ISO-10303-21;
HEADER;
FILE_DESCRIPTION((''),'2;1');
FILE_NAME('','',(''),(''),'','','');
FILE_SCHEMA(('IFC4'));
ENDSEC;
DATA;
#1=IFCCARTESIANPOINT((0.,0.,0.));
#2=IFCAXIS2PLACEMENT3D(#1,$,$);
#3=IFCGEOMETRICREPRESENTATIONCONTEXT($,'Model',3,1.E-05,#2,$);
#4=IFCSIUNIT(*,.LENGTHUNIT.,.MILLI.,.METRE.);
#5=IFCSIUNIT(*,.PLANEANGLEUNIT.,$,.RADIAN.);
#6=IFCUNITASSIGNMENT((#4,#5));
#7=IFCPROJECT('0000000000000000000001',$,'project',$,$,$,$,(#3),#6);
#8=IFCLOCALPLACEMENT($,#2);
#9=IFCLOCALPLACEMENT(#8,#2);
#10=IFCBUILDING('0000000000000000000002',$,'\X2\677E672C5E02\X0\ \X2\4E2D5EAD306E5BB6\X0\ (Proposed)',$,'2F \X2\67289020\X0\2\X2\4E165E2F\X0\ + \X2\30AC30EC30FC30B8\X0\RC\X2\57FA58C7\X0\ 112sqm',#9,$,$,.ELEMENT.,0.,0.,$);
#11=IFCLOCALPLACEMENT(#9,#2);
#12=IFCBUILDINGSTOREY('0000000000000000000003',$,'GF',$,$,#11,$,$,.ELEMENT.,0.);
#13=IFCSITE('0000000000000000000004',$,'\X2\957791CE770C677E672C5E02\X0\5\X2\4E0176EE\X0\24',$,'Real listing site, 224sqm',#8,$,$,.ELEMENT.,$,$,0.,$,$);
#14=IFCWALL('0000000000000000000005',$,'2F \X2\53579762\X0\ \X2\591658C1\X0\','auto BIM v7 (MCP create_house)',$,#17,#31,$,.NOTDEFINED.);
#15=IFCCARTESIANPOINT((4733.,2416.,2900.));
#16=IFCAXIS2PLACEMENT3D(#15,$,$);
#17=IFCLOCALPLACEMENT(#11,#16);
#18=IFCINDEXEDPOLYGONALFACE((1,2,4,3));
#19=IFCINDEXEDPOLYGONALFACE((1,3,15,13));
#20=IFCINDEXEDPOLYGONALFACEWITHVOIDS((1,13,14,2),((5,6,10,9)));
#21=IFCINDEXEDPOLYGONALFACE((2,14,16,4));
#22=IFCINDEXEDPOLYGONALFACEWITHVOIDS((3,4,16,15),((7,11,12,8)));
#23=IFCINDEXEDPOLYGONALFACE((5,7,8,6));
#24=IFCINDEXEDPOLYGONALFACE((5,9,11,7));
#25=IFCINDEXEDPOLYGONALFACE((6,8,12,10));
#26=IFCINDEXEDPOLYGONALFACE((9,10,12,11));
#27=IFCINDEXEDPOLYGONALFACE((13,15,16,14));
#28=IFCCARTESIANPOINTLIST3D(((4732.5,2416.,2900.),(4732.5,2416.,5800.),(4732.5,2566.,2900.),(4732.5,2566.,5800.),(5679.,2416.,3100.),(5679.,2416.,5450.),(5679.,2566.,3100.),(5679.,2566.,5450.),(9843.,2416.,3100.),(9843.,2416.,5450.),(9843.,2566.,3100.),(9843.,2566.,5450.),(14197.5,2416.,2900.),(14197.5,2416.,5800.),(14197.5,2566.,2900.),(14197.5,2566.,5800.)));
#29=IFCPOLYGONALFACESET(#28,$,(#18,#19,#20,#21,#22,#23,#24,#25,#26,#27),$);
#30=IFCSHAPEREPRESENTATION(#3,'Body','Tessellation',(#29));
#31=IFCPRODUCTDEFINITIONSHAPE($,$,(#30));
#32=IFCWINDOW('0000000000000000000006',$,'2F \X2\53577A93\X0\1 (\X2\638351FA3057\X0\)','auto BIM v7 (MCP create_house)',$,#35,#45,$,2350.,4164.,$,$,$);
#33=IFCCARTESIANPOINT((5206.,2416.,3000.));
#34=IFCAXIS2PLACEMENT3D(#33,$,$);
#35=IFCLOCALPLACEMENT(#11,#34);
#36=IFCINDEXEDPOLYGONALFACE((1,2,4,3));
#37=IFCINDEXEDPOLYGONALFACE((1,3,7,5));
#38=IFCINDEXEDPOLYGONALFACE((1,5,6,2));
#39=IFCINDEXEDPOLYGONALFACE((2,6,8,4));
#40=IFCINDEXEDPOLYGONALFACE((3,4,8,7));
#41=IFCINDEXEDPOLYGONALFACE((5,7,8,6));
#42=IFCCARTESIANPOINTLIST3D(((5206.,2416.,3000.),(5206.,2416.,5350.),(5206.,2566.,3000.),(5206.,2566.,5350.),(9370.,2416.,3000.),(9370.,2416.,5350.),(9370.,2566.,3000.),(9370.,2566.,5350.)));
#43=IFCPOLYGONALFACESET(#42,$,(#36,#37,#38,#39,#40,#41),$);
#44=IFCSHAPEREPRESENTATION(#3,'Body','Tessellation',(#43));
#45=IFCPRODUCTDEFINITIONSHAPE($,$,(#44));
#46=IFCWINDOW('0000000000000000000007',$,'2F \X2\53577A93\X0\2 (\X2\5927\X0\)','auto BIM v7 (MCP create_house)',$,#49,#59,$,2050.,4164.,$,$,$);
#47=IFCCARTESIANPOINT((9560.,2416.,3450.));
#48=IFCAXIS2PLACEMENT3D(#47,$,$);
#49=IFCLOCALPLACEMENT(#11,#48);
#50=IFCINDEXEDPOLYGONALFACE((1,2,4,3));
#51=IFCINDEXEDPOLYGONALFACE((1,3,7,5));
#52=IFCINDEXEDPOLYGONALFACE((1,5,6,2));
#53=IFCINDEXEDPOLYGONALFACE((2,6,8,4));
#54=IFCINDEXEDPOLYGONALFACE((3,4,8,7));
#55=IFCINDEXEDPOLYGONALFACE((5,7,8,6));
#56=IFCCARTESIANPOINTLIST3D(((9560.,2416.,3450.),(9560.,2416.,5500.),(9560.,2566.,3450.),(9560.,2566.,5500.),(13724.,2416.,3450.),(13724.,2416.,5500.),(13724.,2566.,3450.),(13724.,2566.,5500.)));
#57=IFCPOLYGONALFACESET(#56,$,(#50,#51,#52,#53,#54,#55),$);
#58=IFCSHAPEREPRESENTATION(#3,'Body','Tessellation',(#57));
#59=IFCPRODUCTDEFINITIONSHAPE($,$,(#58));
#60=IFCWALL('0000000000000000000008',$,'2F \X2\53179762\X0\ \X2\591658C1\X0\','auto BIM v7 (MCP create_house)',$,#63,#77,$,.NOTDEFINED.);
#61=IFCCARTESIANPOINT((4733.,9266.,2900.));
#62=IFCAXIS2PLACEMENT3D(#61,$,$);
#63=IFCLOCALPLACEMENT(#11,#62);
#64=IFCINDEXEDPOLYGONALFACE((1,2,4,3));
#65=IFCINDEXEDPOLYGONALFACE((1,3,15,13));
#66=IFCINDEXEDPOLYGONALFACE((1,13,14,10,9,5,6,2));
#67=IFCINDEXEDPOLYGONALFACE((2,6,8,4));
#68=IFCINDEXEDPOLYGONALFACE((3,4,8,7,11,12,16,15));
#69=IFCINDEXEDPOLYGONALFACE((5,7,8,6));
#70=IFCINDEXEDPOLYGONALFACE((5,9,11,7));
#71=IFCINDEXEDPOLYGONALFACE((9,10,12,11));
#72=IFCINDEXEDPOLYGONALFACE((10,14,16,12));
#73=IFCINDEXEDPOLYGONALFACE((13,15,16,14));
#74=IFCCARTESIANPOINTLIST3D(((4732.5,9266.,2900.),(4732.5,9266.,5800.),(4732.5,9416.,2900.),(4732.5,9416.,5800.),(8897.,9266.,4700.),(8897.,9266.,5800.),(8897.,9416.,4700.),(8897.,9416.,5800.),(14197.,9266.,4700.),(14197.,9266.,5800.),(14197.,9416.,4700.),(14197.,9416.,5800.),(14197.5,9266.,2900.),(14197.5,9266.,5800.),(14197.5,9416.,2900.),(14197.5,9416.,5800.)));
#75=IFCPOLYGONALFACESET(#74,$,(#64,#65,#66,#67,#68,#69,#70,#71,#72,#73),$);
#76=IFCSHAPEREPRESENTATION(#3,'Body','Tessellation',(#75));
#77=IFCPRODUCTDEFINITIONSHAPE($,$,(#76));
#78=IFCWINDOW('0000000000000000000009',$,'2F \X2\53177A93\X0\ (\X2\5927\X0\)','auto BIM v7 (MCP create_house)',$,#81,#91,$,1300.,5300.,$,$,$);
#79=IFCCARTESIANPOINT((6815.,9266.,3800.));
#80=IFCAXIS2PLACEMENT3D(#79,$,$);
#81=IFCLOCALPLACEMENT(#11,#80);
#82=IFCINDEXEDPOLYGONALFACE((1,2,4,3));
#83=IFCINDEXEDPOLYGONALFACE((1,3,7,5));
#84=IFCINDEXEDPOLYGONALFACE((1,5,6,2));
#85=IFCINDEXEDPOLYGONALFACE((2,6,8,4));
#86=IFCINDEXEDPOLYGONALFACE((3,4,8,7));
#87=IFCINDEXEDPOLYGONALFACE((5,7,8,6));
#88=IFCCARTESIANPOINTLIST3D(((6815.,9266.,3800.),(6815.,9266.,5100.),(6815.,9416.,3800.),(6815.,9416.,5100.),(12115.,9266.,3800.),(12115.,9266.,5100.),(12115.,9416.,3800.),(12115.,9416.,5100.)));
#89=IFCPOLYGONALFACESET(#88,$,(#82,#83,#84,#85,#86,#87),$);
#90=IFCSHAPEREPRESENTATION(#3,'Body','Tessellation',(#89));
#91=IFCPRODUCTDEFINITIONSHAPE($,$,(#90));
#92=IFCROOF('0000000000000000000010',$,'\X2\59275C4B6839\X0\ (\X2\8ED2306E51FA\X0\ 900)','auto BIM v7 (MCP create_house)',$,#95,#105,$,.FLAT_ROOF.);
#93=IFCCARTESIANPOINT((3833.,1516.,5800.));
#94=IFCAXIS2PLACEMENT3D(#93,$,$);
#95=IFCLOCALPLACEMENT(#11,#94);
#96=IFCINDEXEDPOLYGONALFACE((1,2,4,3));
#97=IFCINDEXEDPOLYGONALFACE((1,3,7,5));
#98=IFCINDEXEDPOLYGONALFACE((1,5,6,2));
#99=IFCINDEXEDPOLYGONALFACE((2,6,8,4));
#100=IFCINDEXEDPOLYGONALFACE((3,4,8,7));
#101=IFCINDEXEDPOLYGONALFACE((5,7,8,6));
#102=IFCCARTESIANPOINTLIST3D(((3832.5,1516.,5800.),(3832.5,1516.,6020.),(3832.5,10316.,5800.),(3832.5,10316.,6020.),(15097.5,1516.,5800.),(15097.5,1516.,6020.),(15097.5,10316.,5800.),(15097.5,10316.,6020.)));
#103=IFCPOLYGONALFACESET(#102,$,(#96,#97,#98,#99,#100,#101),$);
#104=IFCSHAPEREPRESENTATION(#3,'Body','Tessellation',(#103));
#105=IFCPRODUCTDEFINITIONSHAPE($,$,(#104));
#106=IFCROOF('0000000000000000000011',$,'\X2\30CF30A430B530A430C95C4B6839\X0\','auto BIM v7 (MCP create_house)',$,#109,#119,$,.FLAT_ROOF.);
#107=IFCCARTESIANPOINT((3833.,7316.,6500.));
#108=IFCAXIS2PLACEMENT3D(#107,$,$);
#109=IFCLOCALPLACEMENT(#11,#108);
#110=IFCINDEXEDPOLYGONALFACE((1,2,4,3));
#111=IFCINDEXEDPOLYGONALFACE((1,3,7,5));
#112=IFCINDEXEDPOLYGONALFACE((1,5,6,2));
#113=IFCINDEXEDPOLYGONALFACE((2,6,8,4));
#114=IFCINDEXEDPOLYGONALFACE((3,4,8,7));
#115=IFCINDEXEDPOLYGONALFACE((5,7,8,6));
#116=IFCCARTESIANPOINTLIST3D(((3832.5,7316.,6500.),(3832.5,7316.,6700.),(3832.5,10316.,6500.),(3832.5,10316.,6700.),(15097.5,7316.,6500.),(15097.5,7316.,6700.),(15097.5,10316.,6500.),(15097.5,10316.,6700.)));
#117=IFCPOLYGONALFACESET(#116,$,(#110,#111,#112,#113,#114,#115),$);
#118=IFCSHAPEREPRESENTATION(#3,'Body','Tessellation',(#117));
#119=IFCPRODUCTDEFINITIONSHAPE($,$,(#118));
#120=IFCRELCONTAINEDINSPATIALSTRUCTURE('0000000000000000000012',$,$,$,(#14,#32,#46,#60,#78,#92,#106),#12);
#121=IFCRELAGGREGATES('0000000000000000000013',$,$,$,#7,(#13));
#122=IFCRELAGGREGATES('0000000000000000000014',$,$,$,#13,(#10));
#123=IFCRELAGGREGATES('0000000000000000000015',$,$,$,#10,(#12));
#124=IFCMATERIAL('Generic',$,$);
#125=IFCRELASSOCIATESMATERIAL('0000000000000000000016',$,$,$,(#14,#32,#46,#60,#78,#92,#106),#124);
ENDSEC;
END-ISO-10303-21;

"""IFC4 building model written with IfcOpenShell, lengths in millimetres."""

from ifc_helpers import new_model, si_unit, frame, frame_2d, origin, place, context, project, spatial, rectangle, extrude, material, element, fill, save


model = new_model("IFC4")

# Units and contexts
model_context = context("Model", 3, precision=1e-05, world=origin())
ifc_project = project(units=[si_unit("LENGTHUNIT", "METRE", prefix="MILLI"), si_unit("PLANEANGLEUNIT", "RADIAN")], contexts=[model_context])

# Site, building, storey
site_placement = place(None, origin())
site = spatial("IfcSite", under=ifc_project, at=site_placement, Name="長野県松本市5丁目24", ObjectType="Real listing site, 224sqm", CompositionType="ELEMENT", RefElevation=0.0)
building_placement = place(site_placement, origin())
building = spatial("IfcBuilding", under=site, at=building_placement, Name="松本市 中庭の家 (Proposed)", ObjectType="2F 木造2世帯 + ガレージRC基壇 112sqm", CompositionType="ELEMENT", ElevationOfRefHeight=0.0, ElevationOfTerrain=0.0)
storey_placement = place(building_placement, origin())
storey = spatial("IfcBuildingStorey", under=building, at=storey_placement, Name="GF", CompositionType="ELEMENT", Elevation=0.0)

# Shared definitions
ifc_material = material(Name="Generic")

# Wall, openings, windows
wall_1_placement = place(storey_placement, frame((4733.0, 2416.0, 2900.0)))
wall_1 = element("IfcWall", 1, at=wall_1_placement, inside=storey, material=ifc_material, Name="2F 南面 外壁", Description="auto BIM v7 (MCP create_house)", PredefinedType="NOTDEFINED", context=model_context, shape_type="SweptSolid", body=[
    extrude(rectangle(XDim=9465.0, YDim=150.0, at=frame_2d((4732.0, 75.0))), frame((4733.0, 2416.0, 2900.0)), (0.0, 0.0, 1.0), 2900.0),
])
opening_1_placement = place(storey_placement, frame((5206.0, 2416.0, 3000.0)))
opening_1 = element("IfcOpeningElement", 2, at=opening_1_placement, cuts=wall_1, PredefinedType="NOTDEFINED", context=model_context, shape_type="SweptSolid", body=[
    extrude(rectangle(XDim=4164.0, YDim=150.0, at=frame_2d((2082.0, 75.0))), frame((5206.0, 2416.0, 3000.0)), (0.0, 0.0, 1.0), 2350.0),
])
opening_2_placement = place(storey_placement, frame((9560.0, 2416.0, 3450.0)))
opening_2 = element("IfcOpeningElement", 3, at=opening_2_placement, cuts=wall_1, PredefinedType="NOTDEFINED", context=model_context, shape_type="SweptSolid", body=[
    extrude(rectangle(XDim=4164.0, YDim=150.0, at=frame_2d((2082.0, 75.0))), frame((9560.0, 2416.0, 3450.0)), (0.0, 0.0, 1.0), 2050.0),
])
window_1_placement = place(storey_placement, frame((5206.0, 2416.0, 3000.0)))
window_1 = element("IfcWindow", 4, at=window_1_placement, inside=storey, material=ifc_material, Name="2F 南窓1 (掃出し)", Description="auto BIM v7 (MCP create_house)", OverallHeight=2350.0, OverallWidth=4164.0, context=model_context, shape_type="SweptSolid", body=[
    extrude(rectangle(XDim=4164.0, YDim=150.0, at=frame_2d((2082.0, 75.0))), frame((5206.0, 2416.0, 3000.0)), (0.0, 0.0, 1.0), 2350.0),
])
fill(opening_1, window_1)
window_2_placement = place(storey_placement, frame((9560.0, 2416.0, 3450.0)))
window_2 = element("IfcWindow", 5, at=window_2_placement, inside=storey, material=ifc_material, Name="2F 南窓2 (大)", Description="auto BIM v7 (MCP create_house)", OverallHeight=2050.0, OverallWidth=4164.0, context=model_context, shape_type="SweptSolid", body=[
    extrude(rectangle(XDim=4164.0, YDim=150.0, at=frame_2d((2082.0, 75.0))), frame((9560.0, 2416.0, 3450.0)), (0.0, 0.0, 1.0), 2050.0),
])
fill(opening_2, window_2)

# Wall, opening, window
wall_2_placement = place(storey_placement, frame((4733.0, 9266.0, 2900.0)))
wall_2 = element("IfcWall", 6, at=wall_2_placement, inside=storey, material=ifc_material, Name="2F 北面 外壁", Description="auto BIM v7 (MCP create_house)", PredefinedType="NOTDEFINED", context=model_context, shape_type="SweptSolid", body=[
    extrude(rectangle(XDim=9465.0, YDim=150.0, at=frame_2d((4732.0, 75.0))), frame((4733.0, 9266.0, 2900.0)), (0.0, 0.0, 1.0), 2900.0),
])
opening_3_placement = place(storey_placement, frame((6815.0, 9266.0, 3800.0)))
opening_3 = element("IfcOpeningElement", 7, at=opening_3_placement, cuts=wall_2, PredefinedType="NOTDEFINED", context=model_context, shape_type="SweptSolid", body=[
    extrude(rectangle(XDim=5300.0, YDim=150.0, at=frame_2d((2650.0, 75.0))), frame((6815.0, 9266.0, 3800.0)), (0.0, 0.0, 1.0), 1300.0),
])
window_3_placement = place(storey_placement, frame((6815.0, 9266.0, 3800.0)))
window_3 = element("IfcWindow", 8, at=window_3_placement, inside=storey, material=ifc_material, Name="2F 北窓 (大)", Description="auto BIM v7 (MCP create_house)", OverallHeight=1300.0, OverallWidth=5300.0, context=model_context, shape_type="SweptSolid", body=[
    extrude(rectangle(XDim=5300.0, YDim=150.0, at=frame_2d((2650.0, 75.0))), frame((6815.0, 9266.0, 3800.0)), (0.0, 0.0, 1.0), 1300.0),
])
fill(opening_3, window_3)

# Roofs
roof_1_placement = place(storey_placement, frame((3833.0, 1516.0, 5800.0)))
element("IfcRoof", 9, at=roof_1_placement, inside=storey, material=ifc_material, Name="大屋根 (軒の出 900)", Description="auto BIM v7 (MCP create_house)", PredefinedType="FLAT_ROOF", context=model_context, shape_type="SweptSolid", body=[
    extrude(rectangle(XDim=11265.0, YDim=8800.0, at=frame_2d((5632.0, 4400.0))), frame((3833.0, 1516.0, 5800.0)), (0.0, 0.0, 1.0), 220.0),
])
roof_2_placement = place(storey_placement, frame((3833.0, 7316.0, 6500.0)))
element("IfcRoof", 10, at=roof_2_placement, inside=storey, material=ifc_material, Name="ハイサイド屋根", Description="auto BIM v7 (MCP create_house)", PredefinedType="FLAT_ROOF", context=model_context, shape_type="SweptSolid", body=[
    extrude(rectangle(XDim=11265.0, YDim=3000.0, at=frame_2d((5632.0, 1500.0))), frame((3833.0, 7316.0, 6500.0)), (0.0, 0.0, 1.0), 200.0),
])

save(model, "model.ifc")
